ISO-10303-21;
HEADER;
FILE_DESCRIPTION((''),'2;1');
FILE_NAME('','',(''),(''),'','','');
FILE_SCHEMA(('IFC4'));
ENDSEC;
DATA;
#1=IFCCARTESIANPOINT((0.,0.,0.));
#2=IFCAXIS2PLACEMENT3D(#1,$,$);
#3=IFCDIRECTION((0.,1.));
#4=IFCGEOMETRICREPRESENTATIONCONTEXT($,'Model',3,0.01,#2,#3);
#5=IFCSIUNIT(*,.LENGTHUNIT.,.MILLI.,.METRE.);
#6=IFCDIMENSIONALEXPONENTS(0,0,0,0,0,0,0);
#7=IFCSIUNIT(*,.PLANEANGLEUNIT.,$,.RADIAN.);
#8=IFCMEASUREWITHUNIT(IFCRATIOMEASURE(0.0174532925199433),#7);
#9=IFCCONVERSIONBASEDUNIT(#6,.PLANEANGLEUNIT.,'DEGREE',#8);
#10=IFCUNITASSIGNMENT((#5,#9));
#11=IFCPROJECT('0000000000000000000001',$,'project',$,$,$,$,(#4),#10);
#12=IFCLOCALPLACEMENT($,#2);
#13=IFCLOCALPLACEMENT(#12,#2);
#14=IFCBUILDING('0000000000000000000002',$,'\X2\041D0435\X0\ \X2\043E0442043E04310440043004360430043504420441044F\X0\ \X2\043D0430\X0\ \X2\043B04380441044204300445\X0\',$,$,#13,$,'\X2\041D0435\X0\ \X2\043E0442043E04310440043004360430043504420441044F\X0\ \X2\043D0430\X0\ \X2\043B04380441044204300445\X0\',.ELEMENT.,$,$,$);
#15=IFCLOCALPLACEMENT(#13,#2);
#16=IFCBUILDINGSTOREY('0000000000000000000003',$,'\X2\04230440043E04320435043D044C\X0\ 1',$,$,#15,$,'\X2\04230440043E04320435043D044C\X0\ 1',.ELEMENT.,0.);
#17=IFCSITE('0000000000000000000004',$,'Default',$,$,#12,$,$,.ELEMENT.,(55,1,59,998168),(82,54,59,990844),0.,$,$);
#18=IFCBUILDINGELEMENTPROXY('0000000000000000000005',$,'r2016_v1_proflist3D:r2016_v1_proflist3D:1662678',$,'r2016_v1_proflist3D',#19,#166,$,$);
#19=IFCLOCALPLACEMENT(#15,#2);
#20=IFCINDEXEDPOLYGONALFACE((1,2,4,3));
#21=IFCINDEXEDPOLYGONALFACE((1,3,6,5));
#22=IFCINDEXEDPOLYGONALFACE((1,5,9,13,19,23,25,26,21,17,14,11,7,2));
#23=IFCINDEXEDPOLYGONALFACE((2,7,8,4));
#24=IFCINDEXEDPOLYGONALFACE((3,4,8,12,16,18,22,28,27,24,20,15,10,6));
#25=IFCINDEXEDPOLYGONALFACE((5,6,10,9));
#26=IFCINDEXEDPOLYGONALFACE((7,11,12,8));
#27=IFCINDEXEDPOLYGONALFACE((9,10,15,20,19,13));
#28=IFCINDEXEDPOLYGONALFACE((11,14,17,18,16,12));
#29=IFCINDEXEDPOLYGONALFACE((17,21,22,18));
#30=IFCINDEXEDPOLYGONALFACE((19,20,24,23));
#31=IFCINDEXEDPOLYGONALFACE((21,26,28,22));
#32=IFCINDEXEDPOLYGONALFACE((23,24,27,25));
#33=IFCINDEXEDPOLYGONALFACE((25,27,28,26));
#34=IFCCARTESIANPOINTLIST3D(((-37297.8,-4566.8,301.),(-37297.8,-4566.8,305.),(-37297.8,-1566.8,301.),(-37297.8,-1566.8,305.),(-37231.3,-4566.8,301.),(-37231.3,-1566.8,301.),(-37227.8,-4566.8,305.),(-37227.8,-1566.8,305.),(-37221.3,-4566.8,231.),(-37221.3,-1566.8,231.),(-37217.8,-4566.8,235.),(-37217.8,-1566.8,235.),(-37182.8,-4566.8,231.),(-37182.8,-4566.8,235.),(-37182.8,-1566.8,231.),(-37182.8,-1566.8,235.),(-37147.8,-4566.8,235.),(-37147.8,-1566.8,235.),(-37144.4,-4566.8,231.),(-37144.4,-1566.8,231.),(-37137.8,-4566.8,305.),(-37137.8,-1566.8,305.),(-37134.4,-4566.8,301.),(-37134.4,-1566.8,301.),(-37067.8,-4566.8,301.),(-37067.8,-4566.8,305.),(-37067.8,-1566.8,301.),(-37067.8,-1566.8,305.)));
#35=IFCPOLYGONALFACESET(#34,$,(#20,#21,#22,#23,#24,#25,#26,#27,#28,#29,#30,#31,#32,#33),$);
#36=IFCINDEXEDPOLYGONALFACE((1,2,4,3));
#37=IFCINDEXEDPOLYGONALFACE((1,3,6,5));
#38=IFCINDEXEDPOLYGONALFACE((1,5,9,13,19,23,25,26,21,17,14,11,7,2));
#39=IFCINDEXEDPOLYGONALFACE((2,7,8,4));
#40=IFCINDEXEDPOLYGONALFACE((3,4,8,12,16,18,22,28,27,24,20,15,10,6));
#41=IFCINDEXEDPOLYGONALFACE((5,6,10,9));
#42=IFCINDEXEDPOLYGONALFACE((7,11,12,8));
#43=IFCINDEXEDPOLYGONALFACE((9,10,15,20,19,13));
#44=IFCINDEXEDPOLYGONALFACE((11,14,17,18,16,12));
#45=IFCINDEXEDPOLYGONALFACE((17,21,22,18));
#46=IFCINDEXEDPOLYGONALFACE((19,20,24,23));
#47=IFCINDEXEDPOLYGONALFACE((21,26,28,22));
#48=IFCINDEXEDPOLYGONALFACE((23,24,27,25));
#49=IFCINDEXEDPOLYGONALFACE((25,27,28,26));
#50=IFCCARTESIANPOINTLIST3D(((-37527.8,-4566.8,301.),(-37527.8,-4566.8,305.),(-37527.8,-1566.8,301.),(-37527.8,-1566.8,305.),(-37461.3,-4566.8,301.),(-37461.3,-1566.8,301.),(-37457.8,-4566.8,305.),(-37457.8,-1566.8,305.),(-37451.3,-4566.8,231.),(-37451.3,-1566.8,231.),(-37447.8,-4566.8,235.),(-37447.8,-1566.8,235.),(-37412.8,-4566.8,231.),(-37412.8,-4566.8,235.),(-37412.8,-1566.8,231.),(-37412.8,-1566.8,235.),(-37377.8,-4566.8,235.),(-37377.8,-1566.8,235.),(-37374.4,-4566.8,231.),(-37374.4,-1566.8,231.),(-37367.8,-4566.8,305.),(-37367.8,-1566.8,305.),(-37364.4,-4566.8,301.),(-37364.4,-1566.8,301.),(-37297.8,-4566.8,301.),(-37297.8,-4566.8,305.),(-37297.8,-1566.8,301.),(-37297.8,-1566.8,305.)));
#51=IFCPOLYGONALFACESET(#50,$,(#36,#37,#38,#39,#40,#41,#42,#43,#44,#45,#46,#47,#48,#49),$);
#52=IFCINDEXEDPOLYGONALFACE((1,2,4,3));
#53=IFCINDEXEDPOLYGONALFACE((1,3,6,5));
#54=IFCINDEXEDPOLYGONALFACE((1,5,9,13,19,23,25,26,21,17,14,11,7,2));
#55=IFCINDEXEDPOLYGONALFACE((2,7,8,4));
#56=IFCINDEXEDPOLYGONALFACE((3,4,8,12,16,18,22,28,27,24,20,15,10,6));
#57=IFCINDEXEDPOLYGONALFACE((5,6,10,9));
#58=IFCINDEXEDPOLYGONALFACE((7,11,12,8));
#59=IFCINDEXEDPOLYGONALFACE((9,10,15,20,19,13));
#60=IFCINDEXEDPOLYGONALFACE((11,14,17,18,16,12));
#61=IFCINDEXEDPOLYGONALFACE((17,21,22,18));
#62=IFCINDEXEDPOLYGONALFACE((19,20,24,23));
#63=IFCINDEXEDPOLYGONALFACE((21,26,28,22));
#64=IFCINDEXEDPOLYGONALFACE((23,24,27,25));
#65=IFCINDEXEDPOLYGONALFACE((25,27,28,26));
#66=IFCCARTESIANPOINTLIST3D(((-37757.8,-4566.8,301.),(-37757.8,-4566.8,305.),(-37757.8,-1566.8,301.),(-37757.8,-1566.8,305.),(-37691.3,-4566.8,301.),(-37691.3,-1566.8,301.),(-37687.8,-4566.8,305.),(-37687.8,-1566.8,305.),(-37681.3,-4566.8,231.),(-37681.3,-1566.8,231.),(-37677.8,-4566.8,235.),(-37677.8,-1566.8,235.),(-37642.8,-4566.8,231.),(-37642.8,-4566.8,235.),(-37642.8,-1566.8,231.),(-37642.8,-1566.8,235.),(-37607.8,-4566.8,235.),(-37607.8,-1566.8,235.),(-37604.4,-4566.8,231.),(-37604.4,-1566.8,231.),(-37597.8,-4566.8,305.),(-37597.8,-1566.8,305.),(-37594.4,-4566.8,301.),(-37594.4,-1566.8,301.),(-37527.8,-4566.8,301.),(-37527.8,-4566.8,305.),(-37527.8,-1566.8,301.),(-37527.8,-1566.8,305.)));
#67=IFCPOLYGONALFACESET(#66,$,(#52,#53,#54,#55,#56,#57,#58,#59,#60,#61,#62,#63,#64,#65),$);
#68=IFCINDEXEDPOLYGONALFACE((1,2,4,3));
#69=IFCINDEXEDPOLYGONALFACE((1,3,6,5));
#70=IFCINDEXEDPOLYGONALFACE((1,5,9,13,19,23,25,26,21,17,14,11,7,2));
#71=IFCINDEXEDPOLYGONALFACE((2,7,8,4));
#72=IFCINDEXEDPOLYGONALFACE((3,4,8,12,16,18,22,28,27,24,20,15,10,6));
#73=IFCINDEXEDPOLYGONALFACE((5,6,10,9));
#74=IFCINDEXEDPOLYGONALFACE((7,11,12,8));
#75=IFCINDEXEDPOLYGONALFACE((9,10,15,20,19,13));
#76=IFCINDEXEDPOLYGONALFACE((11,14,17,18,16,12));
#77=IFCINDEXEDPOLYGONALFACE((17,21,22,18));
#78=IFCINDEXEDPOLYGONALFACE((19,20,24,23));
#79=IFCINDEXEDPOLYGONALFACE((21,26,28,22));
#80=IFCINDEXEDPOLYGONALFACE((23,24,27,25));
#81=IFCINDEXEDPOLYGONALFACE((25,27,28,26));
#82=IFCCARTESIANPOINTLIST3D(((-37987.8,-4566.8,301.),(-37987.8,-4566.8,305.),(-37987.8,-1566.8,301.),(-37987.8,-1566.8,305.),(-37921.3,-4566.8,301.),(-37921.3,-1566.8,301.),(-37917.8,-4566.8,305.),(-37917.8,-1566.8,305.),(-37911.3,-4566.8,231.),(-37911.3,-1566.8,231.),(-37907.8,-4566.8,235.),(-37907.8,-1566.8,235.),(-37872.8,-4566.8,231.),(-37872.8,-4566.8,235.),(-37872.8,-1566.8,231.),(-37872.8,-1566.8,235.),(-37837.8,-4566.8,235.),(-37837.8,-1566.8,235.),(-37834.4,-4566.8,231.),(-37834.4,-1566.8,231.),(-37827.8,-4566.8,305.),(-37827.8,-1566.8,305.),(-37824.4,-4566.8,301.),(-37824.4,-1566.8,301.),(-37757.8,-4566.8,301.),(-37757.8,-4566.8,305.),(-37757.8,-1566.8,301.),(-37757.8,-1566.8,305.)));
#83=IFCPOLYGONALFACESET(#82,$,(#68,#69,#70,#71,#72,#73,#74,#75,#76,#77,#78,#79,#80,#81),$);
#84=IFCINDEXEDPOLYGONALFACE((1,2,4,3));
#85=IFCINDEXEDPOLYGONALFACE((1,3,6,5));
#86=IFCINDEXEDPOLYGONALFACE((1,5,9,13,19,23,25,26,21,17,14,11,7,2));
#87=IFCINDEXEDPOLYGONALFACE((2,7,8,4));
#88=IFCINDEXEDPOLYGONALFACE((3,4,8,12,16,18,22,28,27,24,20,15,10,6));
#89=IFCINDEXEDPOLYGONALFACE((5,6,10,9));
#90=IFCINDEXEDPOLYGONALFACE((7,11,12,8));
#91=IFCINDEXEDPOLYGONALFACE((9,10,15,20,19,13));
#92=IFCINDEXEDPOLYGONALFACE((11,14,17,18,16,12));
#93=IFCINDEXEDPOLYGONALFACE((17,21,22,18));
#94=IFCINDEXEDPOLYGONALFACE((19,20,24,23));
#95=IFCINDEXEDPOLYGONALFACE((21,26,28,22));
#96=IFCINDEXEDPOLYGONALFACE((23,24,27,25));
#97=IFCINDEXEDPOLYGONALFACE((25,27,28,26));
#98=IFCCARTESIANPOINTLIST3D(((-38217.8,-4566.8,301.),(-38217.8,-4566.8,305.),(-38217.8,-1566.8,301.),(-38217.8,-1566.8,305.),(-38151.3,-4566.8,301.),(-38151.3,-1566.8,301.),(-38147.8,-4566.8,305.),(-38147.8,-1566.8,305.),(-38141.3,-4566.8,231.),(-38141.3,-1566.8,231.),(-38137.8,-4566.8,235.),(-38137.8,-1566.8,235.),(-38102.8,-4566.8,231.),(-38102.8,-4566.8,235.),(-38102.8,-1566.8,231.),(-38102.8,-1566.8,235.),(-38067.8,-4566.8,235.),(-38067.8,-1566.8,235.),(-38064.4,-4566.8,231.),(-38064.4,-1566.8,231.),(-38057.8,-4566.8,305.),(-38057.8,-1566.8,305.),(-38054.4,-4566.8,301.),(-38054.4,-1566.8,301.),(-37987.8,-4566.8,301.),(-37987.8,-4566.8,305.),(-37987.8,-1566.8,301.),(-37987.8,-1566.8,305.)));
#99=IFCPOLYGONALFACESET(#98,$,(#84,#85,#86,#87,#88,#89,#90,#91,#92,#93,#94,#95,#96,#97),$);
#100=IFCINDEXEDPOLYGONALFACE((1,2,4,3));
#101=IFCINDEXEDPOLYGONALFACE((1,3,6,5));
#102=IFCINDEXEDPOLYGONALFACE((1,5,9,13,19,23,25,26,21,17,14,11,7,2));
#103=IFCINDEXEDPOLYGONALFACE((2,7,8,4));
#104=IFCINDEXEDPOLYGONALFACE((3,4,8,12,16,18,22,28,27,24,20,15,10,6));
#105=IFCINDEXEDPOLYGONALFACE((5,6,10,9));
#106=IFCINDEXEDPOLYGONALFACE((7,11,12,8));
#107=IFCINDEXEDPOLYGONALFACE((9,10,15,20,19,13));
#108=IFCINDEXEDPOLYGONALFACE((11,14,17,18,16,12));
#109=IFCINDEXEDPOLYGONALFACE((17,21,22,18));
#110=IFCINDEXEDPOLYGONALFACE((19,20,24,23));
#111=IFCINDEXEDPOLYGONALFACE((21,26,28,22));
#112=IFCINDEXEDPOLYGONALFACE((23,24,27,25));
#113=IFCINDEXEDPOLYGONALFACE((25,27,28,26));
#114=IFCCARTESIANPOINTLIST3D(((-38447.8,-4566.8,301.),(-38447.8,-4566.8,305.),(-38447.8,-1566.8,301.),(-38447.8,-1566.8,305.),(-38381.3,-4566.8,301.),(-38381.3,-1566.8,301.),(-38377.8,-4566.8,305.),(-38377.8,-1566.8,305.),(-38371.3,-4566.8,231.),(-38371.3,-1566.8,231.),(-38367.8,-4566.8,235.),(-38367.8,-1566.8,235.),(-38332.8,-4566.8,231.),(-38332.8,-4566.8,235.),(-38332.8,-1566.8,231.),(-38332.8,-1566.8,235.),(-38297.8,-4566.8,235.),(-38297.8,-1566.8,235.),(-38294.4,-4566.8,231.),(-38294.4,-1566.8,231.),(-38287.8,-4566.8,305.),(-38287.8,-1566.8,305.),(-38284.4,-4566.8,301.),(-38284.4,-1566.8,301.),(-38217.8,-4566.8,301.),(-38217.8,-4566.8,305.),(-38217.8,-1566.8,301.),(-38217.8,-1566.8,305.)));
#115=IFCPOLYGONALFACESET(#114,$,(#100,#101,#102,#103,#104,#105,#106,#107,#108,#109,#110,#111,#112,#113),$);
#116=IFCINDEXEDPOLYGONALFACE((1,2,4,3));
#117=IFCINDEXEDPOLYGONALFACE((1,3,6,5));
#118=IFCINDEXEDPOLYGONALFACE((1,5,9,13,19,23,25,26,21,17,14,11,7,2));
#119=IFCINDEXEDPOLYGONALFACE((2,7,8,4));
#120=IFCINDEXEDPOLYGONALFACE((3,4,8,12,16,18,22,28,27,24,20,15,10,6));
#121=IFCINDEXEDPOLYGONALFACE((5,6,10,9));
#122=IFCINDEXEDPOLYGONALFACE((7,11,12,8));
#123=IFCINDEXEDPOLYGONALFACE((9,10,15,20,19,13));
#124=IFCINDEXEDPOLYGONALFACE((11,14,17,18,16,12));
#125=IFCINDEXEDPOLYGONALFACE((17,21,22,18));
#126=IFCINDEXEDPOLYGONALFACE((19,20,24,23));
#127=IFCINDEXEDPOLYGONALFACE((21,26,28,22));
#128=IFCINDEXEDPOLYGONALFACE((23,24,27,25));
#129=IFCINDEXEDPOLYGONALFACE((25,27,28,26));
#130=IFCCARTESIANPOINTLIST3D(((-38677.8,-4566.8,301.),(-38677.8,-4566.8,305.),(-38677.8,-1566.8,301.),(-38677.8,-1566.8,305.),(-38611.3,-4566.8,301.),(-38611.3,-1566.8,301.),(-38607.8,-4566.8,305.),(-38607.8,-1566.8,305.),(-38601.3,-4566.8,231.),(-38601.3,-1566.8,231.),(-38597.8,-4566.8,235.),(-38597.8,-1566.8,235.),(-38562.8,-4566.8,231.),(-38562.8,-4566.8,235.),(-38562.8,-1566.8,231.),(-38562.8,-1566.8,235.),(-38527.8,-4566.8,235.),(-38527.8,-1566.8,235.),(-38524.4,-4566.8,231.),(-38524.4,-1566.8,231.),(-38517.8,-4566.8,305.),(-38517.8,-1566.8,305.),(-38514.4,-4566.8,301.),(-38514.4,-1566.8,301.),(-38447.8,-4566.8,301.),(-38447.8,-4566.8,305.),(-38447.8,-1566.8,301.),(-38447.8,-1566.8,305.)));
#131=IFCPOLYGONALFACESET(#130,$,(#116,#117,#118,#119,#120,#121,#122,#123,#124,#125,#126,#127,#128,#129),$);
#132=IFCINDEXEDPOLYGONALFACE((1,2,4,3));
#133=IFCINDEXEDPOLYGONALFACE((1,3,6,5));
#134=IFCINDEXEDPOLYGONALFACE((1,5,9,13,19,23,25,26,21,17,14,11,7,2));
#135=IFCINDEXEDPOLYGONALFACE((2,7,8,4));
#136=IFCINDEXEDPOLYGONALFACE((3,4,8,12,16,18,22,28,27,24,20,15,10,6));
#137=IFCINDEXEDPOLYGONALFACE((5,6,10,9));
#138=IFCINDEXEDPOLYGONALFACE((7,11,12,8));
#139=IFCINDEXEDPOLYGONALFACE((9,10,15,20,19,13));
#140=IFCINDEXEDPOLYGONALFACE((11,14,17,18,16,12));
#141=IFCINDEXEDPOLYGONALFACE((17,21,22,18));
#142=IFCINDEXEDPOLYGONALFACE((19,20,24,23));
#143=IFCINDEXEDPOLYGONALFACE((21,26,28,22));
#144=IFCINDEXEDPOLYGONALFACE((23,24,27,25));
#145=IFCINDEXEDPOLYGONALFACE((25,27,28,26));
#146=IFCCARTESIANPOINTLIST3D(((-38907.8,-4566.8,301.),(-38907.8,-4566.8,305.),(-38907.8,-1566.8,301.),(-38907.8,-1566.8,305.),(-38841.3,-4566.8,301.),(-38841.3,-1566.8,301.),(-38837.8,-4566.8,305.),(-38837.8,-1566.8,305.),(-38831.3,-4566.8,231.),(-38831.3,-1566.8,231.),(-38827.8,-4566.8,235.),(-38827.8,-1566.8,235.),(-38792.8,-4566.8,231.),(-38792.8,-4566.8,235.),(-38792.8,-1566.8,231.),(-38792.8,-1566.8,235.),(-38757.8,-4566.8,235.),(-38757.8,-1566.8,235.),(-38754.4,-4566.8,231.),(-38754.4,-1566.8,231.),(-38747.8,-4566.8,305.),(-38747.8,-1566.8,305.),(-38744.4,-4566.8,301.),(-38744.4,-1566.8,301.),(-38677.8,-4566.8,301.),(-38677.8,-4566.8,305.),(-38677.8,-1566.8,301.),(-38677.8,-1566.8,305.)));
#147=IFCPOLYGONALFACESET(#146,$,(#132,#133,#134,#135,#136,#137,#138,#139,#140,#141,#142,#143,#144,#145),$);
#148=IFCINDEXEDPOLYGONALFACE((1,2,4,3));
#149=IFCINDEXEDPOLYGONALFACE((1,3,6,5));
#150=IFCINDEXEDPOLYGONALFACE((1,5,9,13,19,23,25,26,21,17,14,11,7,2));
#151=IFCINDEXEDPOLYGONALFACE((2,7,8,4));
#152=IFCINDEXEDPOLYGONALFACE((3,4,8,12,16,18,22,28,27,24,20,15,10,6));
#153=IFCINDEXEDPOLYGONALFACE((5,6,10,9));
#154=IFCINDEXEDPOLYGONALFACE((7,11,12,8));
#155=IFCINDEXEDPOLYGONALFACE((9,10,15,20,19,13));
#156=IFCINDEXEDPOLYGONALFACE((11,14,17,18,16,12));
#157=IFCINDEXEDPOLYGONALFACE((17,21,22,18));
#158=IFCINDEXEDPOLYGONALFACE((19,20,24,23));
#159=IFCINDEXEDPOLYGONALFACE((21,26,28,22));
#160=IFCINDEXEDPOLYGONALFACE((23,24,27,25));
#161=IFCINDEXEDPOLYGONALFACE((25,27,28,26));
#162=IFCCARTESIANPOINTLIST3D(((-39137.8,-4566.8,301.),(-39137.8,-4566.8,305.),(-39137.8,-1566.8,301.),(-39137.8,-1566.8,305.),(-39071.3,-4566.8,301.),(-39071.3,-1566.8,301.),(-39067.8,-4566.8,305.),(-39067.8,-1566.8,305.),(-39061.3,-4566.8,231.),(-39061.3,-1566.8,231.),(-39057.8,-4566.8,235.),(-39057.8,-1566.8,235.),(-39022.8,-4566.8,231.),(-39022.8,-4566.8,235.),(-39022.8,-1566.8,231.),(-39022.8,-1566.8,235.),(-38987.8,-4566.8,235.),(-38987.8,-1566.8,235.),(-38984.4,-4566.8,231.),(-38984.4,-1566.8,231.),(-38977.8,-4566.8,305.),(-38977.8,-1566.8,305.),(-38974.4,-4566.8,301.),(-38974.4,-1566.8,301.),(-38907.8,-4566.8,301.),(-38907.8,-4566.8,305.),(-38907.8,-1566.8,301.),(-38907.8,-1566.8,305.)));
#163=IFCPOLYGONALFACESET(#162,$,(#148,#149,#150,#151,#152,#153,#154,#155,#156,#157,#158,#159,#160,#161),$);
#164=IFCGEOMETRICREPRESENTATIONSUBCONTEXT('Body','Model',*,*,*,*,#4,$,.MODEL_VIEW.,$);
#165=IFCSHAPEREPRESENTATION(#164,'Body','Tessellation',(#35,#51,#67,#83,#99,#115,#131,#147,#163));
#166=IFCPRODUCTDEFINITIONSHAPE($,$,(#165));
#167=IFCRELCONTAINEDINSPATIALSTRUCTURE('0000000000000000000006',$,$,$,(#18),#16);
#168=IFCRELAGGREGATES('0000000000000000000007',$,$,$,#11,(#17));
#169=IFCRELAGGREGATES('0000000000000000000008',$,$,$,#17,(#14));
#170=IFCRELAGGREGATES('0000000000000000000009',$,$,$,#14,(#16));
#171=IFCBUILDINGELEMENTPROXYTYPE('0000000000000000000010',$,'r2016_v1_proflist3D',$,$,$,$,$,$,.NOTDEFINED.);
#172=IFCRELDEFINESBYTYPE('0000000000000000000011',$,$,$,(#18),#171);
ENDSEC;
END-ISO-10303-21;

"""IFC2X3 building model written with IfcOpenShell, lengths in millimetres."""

from ifc_helpers import new_model, entity, si_unit, converted_unit, direction, frame, origin, place, context, subcontext, project, spatial, polyline, outline, extrude, source, transform, mapped, type_object, type_shapes, element, save


model = new_model("IFC2X3")

# Units and contexts
model_context = context("Model", 3, precision=0.01, world=origin(), true_north=direction((0.0, 1.0)))
body_context = subcontext(model_context, "Body", "Model", "MODEL_VIEW")
ifc_project = project(units=[si_unit("LENGTHUNIT", "METRE", prefix="MILLI"), converted_unit("PLANEANGLEUNIT", "DEGREE", entity("IfcRatioMeasure", 0.0174532925199433), si_unit("PLANEANGLEUNIT", "RADIAN"), dimensions=[0, 0, 0, 0, 0, 0, 0])], contexts=[model_context])

# Site, building, storey
site_placement = place(None, origin())
site = spatial("IfcSite", under=ifc_project, at=site_placement, Name="Default", CompositionType="ELEMENT", RefLatitude=(55, 1, 59, 998168), RefLongitude=(82, 54, 59, 990844), RefElevation=0.0)
building_placement = place(site_placement, origin())
building = spatial("IfcBuilding", under=site, at=building_placement, Name="Не отображается на листах", LongName="Не отображается на листах", CompositionType="ELEMENT")
storey_placement = place(building_placement, frame((0.0, 0.0, 0.0)))
storey = spatial("IfcBuildingStorey", under=building, at=storey_placement, Name="Уровень 1", LongName="Уровень 1", CompositionType="ELEMENT", Elevation=0.0)

# Building element proxy
building_element_proxy_type = type_object("IfcBuildingElementProxyType", Name="r2016_v1_proflist3D", PredefinedType="NOTDEFINED")
shared_shape = source(origin(), body_context, "Body", "SweptSolid", [
    extrude(outline(polyline([(-38.0, -40.0), (-47.9, -109.3), (-44.0, -109.9), (-34.6, -44.0), (36.1, -44.0), (41.6, -5.9), (47.0, 32.1), (-20.9, 51.9), (-11.5, 117.8), (-15.4, 118.4), (-25.3, 49.1), (42.6, 29.3), (37.6, -5.4), (32.7, -40.0), (-38.0, -40.0)])), frame((1955.0, -3000.0, -32.0), z_axis=(0.0, -1.0, 0.0), x_axis=(0.141421, 0.0, -0.989949)), (0.0, 0.0, -1.0), 3000.0),
    extrude(outline(polyline([(-38.0, -40.0), (-47.9, -109.3), (-44.0, -109.9), (-34.6, -44.0), (36.1, -44.0), (41.6, -5.9), (47.0, 32.1), (-20.9, 51.9), (-11.5, 117.8), (-15.4, 118.4), (-25.3, 49.1), (42.6, 29.3), (37.6, -5.4), (32.7, -40.0), (-38.0, -40.0)])), frame((1725.0, -3000.0, -32.0), z_axis=(0.0, -1.0, 0.0), x_axis=(0.141421, 0.0, -0.989949)), (0.0, 0.0, -1.0), 3000.0),
    extrude(outline(polyline([(-38.0, -40.0), (-47.9, -109.3), (-44.0, -109.9), (-34.6, -44.0), (36.1, -44.0), (41.6, -5.9), (47.0, 32.1), (-20.9, 51.9), (-11.5, 117.8), (-15.4, 118.4), (-25.3, 49.1), (42.6, 29.3), (37.6, -5.4), (32.7, -40.0), (-38.0, -40.0)])), frame((1495.0, -3000.0, -32.0), z_axis=(0.0, -1.0, 0.0), x_axis=(0.141421, 0.0, -0.989949)), (0.0, 0.0, -1.0), 3000.0),
    extrude(outline(polyline([(-38.0, -40.0), (-47.9, -109.3), (-44.0, -109.9), (-34.6, -44.0), (36.1, -44.0), (41.6, -5.9), (47.0, 32.1), (-20.9, 51.9), (-11.5, 117.8), (-15.4, 118.4), (-25.3, 49.1), (42.6, 29.3), (37.6, -5.4), (32.7, -40.0), (-38.0, -40.0)])), frame((1265.0, -3000.0, -32.0), z_axis=(0.0, -1.0, 0.0), x_axis=(0.141421, 0.0, -0.989949)), (0.0, 0.0, -1.0), 3000.0),
    extrude(outline(polyline([(-38.0, -40.0), (-47.9, -109.3), (-44.0, -109.9), (-34.6, -44.0), (36.1, -44.0), (41.6, -5.9), (47.0, 32.1), (-20.9, 51.9), (-11.5, 117.8), (-15.4, 118.4), (-25.3, 49.1), (42.6, 29.3), (37.6, -5.4), (32.7, -40.0), (-38.0, -40.0)])), frame((1035.0, -3000.0, -32.0), z_axis=(0.0, -1.0, 0.0), x_axis=(0.141421, 0.0, -0.989949)), (0.0, 0.0, -1.0), 3000.0),
    extrude(outline(polyline([(-38.0, -40.0), (-47.9, -109.3), (-44.0, -109.9), (-34.6, -44.0), (36.1, -44.0), (41.6, -5.9), (47.0, 32.1), (-20.9, 51.9), (-11.5, 117.8), (-15.4, 118.4), (-25.3, 49.1), (42.6, 29.3), (37.6, -5.4), (32.7, -40.0), (-38.0, -40.0)])), frame((805.0, -3000.0, -32.0), z_axis=(0.0, -1.0, 0.0), x_axis=(0.141421, 0.0, -0.989949)), (0.0, 0.0, -1.0), 3000.0),
    extrude(outline(polyline([(-38.0, -40.0), (-47.9, -109.3), (-44.0, -109.9), (-34.6, -44.0), (36.1, -44.0), (41.6, -5.9), (47.0, 32.1), (-20.9, 51.9), (-11.5, 117.8), (-15.4, 118.4), (-25.3, 49.1), (42.6, 29.3), (37.6, -5.4), (32.7, -40.0), (-38.0, -40.0)])), frame((575.0, -3000.0, -32.0), z_axis=(0.0, -1.0, 0.0), x_axis=(0.141421, 0.0, -0.989949)), (0.0, 0.0, -1.0), 3000.0),
    extrude(outline(polyline([(-38.0, -40.0), (-47.9, -109.3), (-44.0, -109.9), (-34.6, -44.0), (36.1, -44.0), (41.6, -5.9), (47.0, 32.1), (-20.9, 51.9), (-11.5, 117.8), (-15.4, 118.4), (-25.3, 49.1), (42.6, 29.3), (37.6, -5.4), (32.7, -40.0), (-38.0, -40.0)])), frame((345.0, -3000.0, -32.0), z_axis=(0.0, -1.0, 0.0), x_axis=(0.141421, 0.0, -0.989949)), (0.0, 0.0, -1.0), 3000.0),
    extrude(outline(polyline([(-38.0, -40.0), (-47.9, -109.3), (-44.0, -109.9), (-34.6, -44.0), (36.1, -44.0), (41.6, -5.9), (47.0, 32.1), (-20.9, 51.9), (-11.5, 117.8), (-15.4, 118.4), (-25.3, 49.1), (42.6, 29.3), (37.6, -5.4), (32.7, -40.0), (-38.0, -40.0)])), frame((115.0, -3000.0, -32.0), z_axis=(0.0, -1.0, 0.0), x_axis=(0.141421, 0.0, -0.989949)), (0.0, 0.0, -1.0), 3000.0),
])
type_shapes(building_element_proxy_type, [shared_shape])
proxy_1_placement = place(storey_placement, frame((-39137.8, -1566.8, 305.0)))
element("IfcBuildingElementProxy", 1, at=proxy_1_placement, inside=storey, type_object=building_element_proxy_type, Name="r2016_v1_proflist3D:r2016_v1_proflist3D:1662678", ObjectType="r2016_v1_proflist3D", context=body_context, shape_type="MappedRepresentation", body=[
    mapped(shared_shape, transform((0.0, 0.0, 0.0), scale=1.0)),
])

save(model, "model.ifc")
